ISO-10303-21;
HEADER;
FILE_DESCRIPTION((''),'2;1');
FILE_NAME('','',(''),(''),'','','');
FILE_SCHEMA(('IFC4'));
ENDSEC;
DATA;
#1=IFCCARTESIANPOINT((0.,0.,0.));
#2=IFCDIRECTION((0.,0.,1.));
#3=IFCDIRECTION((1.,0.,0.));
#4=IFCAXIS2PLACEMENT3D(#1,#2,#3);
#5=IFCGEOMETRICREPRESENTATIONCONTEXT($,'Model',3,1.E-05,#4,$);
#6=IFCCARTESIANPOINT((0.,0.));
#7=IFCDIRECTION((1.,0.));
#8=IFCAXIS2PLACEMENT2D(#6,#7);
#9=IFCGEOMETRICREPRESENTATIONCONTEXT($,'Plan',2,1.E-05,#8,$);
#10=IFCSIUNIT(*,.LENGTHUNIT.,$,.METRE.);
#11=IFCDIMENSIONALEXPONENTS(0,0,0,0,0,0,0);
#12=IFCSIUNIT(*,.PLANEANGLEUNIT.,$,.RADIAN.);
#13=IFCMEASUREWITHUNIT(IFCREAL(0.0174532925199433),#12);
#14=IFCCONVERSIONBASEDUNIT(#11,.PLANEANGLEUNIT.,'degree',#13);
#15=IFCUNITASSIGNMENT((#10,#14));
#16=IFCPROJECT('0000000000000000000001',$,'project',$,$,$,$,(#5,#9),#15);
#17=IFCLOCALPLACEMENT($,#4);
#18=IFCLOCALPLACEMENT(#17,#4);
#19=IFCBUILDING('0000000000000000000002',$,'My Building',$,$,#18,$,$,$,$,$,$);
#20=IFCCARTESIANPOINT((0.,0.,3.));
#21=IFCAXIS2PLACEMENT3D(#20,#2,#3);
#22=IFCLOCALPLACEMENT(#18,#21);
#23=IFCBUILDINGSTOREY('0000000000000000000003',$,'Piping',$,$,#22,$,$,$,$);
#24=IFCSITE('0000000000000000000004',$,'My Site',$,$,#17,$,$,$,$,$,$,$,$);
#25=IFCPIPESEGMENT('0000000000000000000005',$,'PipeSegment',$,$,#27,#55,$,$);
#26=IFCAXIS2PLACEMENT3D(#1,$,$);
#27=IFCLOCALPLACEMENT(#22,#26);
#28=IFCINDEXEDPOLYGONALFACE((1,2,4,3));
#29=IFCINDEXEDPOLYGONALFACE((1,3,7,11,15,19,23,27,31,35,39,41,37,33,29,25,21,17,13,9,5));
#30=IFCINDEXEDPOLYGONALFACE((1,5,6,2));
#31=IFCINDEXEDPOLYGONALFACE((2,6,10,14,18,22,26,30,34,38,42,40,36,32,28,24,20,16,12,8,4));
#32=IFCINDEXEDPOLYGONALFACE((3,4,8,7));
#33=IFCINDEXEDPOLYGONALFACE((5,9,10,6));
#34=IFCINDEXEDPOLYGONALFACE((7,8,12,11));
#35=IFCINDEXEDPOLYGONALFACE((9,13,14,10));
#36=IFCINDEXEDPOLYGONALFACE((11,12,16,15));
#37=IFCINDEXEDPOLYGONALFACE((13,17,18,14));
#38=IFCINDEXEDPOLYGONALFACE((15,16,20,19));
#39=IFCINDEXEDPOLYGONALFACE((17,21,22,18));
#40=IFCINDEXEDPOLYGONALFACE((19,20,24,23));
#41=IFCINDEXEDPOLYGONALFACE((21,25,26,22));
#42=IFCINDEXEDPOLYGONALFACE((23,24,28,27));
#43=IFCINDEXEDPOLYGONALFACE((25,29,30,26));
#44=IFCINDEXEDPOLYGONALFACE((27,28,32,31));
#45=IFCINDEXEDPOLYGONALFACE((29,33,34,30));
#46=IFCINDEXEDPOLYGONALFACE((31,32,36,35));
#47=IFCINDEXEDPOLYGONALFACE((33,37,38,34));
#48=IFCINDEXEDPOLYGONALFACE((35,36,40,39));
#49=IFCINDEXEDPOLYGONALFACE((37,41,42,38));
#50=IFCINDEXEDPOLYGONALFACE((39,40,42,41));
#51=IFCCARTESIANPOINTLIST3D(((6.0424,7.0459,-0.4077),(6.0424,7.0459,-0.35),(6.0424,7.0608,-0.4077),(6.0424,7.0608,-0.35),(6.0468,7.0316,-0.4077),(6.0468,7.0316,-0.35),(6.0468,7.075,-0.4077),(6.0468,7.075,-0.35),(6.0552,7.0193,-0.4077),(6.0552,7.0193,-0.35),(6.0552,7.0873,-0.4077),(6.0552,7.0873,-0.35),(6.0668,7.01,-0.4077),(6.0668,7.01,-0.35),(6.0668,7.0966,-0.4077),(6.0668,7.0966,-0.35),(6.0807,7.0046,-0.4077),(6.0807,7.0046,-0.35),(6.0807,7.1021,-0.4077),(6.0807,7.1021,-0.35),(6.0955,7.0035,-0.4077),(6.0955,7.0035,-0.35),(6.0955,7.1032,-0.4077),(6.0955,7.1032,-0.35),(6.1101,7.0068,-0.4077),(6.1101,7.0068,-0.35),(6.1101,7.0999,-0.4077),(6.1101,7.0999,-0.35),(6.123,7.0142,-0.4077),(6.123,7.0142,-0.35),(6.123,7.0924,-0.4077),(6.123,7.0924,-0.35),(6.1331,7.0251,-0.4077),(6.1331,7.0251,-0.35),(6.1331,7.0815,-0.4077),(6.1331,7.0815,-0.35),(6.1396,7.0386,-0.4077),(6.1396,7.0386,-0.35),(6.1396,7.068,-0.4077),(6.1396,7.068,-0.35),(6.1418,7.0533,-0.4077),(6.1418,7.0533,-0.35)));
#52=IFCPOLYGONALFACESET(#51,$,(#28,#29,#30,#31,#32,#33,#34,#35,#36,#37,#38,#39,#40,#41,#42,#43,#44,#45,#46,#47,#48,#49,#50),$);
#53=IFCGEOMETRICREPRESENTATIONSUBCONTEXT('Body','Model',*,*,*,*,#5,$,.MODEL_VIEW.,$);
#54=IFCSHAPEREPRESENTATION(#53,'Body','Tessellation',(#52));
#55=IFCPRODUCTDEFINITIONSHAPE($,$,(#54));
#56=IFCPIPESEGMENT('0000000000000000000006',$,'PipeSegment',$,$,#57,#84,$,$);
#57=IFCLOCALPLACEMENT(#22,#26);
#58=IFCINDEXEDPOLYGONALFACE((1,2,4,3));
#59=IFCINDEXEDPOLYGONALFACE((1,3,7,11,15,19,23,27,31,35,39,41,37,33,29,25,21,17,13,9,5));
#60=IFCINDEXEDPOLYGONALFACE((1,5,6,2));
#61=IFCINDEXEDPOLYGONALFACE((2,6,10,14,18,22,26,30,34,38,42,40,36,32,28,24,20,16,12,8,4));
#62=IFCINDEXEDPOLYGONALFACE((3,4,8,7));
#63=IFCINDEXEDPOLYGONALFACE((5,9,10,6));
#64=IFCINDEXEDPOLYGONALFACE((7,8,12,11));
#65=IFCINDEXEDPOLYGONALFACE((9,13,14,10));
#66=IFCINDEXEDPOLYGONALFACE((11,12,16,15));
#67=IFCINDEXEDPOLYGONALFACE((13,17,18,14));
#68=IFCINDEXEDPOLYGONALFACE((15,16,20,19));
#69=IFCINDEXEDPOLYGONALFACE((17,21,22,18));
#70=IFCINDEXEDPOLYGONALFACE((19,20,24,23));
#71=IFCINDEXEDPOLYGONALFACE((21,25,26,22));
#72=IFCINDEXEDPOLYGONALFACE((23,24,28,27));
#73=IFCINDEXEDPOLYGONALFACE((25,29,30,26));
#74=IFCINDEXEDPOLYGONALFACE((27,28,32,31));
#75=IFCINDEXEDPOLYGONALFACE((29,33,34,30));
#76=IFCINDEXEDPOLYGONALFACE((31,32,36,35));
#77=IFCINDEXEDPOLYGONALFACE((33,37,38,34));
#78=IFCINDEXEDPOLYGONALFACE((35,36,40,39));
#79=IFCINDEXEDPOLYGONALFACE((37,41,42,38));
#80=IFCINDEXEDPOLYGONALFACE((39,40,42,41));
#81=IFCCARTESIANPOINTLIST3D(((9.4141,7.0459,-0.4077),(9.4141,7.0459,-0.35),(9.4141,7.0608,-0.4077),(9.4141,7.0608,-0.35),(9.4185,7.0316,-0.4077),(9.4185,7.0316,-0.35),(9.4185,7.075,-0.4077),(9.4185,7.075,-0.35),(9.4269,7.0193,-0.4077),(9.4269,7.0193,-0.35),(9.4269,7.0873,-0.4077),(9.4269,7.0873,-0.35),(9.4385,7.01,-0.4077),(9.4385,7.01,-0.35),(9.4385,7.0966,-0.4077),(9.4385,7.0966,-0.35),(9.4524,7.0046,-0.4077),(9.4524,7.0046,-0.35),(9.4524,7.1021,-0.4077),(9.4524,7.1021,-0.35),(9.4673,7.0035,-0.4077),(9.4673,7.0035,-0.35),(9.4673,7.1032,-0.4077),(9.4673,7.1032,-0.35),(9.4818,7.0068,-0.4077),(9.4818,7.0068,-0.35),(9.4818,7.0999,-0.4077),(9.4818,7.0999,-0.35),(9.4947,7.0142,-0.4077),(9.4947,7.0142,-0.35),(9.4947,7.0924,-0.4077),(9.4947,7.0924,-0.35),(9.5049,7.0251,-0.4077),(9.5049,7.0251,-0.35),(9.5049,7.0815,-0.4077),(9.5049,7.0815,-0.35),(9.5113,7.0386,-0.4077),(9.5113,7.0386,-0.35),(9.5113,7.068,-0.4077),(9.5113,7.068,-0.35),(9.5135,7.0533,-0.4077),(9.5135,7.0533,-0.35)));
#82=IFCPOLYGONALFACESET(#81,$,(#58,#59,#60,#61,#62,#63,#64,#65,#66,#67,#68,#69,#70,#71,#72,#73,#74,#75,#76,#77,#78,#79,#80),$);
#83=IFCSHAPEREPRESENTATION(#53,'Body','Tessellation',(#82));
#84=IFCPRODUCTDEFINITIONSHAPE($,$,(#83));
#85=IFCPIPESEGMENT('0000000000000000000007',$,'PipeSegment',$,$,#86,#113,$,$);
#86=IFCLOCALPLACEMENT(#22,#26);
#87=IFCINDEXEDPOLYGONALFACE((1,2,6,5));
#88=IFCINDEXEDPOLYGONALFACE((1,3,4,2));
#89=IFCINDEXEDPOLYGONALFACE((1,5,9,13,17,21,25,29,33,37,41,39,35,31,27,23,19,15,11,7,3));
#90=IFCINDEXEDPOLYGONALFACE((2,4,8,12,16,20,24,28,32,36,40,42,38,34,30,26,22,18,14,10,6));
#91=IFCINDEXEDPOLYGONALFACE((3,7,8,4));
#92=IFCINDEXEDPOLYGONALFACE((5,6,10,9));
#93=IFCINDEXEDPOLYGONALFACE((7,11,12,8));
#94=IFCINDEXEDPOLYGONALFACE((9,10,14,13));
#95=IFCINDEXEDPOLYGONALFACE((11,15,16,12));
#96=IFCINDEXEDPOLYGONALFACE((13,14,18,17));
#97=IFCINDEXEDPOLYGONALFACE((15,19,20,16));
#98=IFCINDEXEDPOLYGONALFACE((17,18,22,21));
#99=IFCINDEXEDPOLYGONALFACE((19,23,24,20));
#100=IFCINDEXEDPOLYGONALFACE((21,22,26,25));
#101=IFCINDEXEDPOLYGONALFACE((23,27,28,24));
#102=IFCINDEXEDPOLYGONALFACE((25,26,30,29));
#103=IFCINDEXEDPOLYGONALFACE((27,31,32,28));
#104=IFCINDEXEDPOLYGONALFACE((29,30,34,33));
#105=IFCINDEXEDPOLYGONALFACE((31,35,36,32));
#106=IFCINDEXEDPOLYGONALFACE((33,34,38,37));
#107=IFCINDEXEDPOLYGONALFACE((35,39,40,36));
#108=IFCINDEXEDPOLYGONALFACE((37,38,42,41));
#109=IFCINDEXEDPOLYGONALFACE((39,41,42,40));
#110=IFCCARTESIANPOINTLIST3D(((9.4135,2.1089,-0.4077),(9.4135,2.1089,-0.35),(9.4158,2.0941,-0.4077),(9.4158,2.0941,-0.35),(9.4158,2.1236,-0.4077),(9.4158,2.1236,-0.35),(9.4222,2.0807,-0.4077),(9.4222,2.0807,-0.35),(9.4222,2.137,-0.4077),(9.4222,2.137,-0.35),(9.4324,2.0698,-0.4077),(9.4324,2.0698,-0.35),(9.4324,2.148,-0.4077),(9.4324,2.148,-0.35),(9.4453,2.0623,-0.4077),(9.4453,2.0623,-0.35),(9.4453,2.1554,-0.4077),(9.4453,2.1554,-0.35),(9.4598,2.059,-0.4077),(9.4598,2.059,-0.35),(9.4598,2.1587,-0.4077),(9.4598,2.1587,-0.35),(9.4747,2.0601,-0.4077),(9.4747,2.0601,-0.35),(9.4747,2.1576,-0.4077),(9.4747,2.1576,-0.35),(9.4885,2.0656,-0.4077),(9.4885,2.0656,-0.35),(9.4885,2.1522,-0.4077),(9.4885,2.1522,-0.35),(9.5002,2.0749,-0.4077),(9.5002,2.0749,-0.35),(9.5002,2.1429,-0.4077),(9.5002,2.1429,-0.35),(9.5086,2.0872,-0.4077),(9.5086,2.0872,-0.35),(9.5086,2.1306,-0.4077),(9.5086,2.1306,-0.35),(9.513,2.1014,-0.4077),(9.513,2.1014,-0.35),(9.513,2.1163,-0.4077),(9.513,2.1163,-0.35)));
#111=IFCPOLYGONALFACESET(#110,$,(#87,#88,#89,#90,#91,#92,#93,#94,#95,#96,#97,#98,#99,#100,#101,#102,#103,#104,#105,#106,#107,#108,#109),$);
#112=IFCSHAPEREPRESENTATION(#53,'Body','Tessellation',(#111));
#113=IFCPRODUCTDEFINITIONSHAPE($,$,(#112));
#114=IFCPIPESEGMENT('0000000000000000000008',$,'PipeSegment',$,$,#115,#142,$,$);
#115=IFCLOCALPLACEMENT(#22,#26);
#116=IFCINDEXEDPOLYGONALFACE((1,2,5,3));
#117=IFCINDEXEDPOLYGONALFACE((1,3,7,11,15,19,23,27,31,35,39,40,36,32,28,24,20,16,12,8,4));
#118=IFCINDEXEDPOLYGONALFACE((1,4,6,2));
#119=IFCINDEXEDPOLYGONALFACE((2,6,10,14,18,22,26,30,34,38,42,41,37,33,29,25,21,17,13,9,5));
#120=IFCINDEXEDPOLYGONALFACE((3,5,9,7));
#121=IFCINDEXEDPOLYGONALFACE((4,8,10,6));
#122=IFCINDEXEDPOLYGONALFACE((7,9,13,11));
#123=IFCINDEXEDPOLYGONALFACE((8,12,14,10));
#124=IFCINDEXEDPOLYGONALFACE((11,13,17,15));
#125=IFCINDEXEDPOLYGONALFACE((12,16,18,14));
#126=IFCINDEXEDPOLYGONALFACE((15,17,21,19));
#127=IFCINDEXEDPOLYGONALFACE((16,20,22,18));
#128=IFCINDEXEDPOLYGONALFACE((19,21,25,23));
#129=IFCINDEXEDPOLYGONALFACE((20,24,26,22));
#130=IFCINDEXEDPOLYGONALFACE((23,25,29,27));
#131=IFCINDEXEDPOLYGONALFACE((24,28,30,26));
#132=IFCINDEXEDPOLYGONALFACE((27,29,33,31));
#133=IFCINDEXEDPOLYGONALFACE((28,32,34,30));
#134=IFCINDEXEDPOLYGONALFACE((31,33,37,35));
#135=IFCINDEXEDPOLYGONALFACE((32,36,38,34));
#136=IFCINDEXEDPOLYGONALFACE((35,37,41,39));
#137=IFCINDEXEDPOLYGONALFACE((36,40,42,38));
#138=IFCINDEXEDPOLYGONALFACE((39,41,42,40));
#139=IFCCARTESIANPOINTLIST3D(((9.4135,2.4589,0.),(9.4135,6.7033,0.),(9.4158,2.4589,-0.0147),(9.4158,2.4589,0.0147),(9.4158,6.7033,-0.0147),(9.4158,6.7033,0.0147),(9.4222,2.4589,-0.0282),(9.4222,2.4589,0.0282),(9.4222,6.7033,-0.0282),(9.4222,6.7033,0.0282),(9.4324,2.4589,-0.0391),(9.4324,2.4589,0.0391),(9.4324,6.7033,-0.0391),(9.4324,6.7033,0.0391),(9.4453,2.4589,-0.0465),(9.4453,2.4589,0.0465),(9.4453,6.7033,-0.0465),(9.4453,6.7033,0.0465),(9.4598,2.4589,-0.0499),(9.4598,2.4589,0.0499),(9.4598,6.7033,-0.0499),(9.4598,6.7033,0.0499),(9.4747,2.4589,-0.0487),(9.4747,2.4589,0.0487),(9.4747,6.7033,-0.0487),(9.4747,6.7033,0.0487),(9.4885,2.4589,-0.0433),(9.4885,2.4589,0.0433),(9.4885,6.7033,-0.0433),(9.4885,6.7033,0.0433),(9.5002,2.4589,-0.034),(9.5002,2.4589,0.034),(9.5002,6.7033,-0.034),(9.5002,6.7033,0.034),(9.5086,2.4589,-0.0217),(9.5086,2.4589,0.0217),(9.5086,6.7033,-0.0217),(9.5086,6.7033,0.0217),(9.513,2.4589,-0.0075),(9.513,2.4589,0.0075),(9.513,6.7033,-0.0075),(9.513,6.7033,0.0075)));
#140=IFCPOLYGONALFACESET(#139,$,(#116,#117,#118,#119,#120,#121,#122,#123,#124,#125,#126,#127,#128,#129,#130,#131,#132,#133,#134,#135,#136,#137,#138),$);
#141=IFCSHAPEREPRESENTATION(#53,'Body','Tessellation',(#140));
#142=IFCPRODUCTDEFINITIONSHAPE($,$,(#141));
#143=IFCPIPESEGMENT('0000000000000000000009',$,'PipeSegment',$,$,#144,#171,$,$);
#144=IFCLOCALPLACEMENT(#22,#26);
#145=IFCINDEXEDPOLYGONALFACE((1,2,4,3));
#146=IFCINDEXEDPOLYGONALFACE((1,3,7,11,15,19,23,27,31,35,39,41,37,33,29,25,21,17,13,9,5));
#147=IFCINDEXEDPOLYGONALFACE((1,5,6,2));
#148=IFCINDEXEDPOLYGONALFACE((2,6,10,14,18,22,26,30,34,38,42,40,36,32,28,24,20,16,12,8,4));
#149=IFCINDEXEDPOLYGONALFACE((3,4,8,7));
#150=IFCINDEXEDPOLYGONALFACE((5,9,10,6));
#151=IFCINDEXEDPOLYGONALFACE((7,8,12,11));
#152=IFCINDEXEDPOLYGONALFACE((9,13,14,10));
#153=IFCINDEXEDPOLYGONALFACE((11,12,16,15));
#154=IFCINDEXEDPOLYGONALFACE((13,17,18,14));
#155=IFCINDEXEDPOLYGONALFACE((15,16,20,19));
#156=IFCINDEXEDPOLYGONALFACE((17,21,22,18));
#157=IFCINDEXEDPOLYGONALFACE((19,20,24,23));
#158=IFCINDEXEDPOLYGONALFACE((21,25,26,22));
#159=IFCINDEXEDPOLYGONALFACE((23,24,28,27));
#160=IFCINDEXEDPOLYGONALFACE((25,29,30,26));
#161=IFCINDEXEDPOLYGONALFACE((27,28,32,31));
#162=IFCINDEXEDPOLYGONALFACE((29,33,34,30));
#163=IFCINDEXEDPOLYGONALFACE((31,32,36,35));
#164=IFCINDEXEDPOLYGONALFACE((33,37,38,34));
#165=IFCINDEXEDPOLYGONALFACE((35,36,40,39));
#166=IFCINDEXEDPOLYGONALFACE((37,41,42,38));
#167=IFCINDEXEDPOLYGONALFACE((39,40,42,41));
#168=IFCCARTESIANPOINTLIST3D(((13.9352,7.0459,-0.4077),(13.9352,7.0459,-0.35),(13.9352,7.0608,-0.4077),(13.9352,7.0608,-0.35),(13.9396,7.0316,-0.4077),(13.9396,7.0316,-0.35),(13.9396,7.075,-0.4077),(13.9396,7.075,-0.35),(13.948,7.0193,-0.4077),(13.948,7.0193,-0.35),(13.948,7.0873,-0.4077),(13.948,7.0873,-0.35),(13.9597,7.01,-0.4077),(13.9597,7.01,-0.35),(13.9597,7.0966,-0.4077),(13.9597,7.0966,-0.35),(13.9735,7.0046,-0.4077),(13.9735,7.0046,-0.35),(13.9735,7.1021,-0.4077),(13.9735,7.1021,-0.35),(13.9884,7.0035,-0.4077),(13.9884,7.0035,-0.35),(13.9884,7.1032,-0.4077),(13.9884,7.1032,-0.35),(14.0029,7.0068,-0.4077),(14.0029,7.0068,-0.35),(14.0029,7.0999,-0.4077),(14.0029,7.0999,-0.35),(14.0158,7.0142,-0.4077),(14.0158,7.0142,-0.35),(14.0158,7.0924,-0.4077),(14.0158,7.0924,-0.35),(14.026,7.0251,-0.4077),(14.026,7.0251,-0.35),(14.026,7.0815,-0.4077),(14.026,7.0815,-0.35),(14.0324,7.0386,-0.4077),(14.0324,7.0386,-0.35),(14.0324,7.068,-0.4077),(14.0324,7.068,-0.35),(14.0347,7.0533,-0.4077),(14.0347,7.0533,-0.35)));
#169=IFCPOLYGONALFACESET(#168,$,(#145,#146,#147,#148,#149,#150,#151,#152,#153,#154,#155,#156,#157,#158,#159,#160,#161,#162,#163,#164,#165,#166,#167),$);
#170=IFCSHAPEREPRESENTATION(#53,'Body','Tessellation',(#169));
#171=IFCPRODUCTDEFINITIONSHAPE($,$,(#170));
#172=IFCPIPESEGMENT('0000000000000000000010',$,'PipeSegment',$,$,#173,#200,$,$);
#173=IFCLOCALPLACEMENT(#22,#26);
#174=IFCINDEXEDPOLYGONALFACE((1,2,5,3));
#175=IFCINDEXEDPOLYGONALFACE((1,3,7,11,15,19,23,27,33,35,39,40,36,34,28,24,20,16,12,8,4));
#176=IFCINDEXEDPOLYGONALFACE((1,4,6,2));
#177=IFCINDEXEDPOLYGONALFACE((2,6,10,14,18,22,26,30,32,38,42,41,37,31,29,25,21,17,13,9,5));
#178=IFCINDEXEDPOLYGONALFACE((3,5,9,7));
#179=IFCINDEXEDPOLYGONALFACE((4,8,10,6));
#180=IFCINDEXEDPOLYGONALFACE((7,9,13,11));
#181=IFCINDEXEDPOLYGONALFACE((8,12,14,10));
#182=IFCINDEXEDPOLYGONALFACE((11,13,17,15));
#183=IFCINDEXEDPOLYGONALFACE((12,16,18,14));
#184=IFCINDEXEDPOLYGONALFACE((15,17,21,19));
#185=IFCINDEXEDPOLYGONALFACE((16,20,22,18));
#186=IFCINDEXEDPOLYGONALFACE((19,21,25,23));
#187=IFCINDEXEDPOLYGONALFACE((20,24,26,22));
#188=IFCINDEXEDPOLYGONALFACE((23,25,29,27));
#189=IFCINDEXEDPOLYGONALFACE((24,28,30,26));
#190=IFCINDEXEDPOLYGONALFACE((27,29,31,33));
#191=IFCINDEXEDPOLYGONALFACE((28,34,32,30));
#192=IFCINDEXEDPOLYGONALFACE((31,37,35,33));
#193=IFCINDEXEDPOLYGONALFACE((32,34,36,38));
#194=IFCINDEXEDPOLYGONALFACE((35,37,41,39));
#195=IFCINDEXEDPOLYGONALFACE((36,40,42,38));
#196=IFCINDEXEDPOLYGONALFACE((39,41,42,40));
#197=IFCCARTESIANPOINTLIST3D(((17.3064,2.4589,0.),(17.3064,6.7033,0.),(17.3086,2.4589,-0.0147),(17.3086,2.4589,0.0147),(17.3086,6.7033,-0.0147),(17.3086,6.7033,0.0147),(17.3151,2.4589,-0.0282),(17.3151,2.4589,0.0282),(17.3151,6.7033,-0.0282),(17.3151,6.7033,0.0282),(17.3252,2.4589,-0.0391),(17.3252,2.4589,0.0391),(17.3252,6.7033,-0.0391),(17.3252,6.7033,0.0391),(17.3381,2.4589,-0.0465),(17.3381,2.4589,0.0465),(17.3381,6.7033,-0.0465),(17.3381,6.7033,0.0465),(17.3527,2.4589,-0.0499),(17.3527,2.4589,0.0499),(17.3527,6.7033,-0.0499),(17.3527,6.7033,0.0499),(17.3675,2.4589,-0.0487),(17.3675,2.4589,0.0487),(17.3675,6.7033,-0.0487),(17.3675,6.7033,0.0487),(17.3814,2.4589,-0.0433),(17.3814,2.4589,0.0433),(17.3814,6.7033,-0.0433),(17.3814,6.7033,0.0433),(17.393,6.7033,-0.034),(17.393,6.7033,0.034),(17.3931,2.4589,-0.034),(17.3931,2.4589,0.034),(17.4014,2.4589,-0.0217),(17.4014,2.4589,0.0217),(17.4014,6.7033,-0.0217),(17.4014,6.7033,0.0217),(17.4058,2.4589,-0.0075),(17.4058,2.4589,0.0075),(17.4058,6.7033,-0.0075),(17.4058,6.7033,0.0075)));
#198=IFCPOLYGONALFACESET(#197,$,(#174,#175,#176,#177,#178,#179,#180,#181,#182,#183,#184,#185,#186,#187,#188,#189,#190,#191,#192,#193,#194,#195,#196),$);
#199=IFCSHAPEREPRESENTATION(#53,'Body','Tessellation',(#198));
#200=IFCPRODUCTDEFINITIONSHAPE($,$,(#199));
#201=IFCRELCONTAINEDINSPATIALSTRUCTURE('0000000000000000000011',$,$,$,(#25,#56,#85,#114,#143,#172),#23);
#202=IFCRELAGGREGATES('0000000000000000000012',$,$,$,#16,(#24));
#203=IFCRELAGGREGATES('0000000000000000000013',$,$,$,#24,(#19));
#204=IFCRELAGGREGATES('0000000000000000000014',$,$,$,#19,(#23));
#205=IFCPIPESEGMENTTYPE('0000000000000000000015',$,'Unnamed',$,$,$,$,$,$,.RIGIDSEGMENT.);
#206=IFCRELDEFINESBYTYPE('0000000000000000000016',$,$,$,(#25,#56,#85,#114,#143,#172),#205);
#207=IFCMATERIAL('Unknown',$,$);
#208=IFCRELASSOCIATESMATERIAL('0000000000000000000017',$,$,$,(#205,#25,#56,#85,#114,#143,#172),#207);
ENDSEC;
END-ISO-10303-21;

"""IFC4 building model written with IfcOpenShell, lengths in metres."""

from ifc_helpers import new_model, entity, si_unit, converted_unit, frame, origin_with_axes, origin_2d_with_axis, place, context, subcontext, project, spatial, circle, extrude, material, material_profile, profile_set, profile_usage, type_object, element, save


model = new_model("IFC4")

# Units and contexts
model_context = context("Model", 3, precision=1e-05, world=origin_with_axes())
plan_context = context("Plan", 2, precision=1e-05, world=origin_2d_with_axis())
body_context = subcontext(model_context, "Body", "Model", "MODEL_VIEW")
ifc_project = project(units=[si_unit("LENGTHUNIT", "METRE"), converted_unit("PLANEANGLEUNIT", "degree", entity("IfcReal", 0.0174532925199433), si_unit("PLANEANGLEUNIT", "RADIAN"), dimensions=[0, 0, 0, 0, 0, 0, 0])], contexts=[model_context, plan_context])

# Site, building, storey
site_placement = place(None, origin_with_axes())
site = spatial("IfcSite", under=ifc_project, at=site_placement, Name="My Site")
building_placement = place(site_placement, origin_with_axes())
building = spatial("IfcBuilding", under=site, at=building_placement, Name="My Building")
storey_placement = place(building_placement, frame((0.0, 0.0, 3.0), z_axis=(0.0, 0.0, 1.0), x_axis=(1.0, 0.0, 0.0)))
storey = spatial("IfcBuildingStorey", under=building, at=storey_placement, Name="Piping")

# Pipe segments
ifc_material = material(Name="Unknown")
ifc_material_profile = material_profile(ifc_material, circle(Radius=0.05))
ifc_profile_set = profile_set([ifc_material_profile])
pipe_segment_type = type_object("IfcPipeSegmentType", Name="Unnamed", PredefinedType="RIGIDSEGMENT", material=ifc_profile_set)
ifc_profile_usage_1 = profile_usage(ifc_profile_set, cardinal=5)
pipe_segment_1_placement = place(storey_placement, frame((6.0918, 7.0533, -0.35), z_axis=(0.0, 0.0, -1.0), x_axis=(1.0, 0.0, 0.0)))
element("IfcPipeSegment", 1, at=pipe_segment_1_placement, inside=storey, type_object=pipe_segment_type, material=ifc_profile_usage_1, Name="PipeSegment", context=body_context, shape_type="SweptSolid", body=[
    extrude(circle(Radius=0.05), origin_with_axes(), (0.0, 0.0, 1.0), 0.0577),
])
ifc_profile_usage_2 = profile_usage(ifc_profile_set, cardinal=5)
pipe_segment_2_placement = place(storey_placement, frame((9.4635, 7.0533, -0.35), z_axis=(0.0, 0.0, -1.0), x_axis=(1.0, 0.0, 0.0)))
element("IfcPipeSegment", 2, at=pipe_segment_2_placement, inside=storey, type_object=pipe_segment_type, material=ifc_profile_usage_2, Name="PipeSegment", context=body_context, shape_type="SweptSolid", body=[
    extrude(circle(Radius=0.05), origin_with_axes(), (0.0, 0.0, 1.0), 0.0577),
])
ifc_profile_usage_3 = profile_usage(ifc_profile_set, cardinal=5)
pipe_segment_3_placement = place(storey_placement, frame((9.4635, 2.1089, -0.35), z_axis=(0.0, 0.0, -1.0), x_axis=(-1.0, 0.0, 0.0)))
element("IfcPipeSegment", 3, at=pipe_segment_3_placement, inside=storey, type_object=pipe_segment_type, material=ifc_profile_usage_3, Name="PipeSegment", context=body_context, shape_type="SweptSolid", body=[
    extrude(circle(Radius=0.05), origin_with_axes(), (0.0, 0.0, 1.0), 0.0577),
])
ifc_profile_usage_4 = profile_usage(ifc_profile_set, cardinal=5)
pipe_segment_4_placement = place(storey_placement, frame((9.4635, 2.4589, 0.0), z_axis=(0.0, 1.0, 0.0), x_axis=(-1.0, 0.0, 0.0)))
element("IfcPipeSegment", 4, at=pipe_segment_4_placement, inside=storey, type_object=pipe_segment_type, material=ifc_profile_usage_4, Name="PipeSegment", context=body_context, shape_type="SweptSolid", body=[
    extrude(circle(Radius=0.05), origin_with_axes(), (0.0, 0.0, 1.0), 4.2444),
])
ifc_profile_usage_5 = profile_usage(ifc_profile_set, cardinal=5)
pipe_segment_5_placement = place(storey_placement, frame((13.9847, 7.0533, -0.35), z_axis=(0.0, 0.0, -1.0), x_axis=(1.0, 0.0, 0.0)))
element("IfcPipeSegment", 5, at=pipe_segment_5_placement, inside=storey, type_object=pipe_segment_type, material=ifc_profile_usage_5, Name="PipeSegment", context=body_context, shape_type="SweptSolid", body=[
    extrude(circle(Radius=0.05), origin_with_axes(), (0.0, 0.0, 1.0), 0.0577),
])
ifc_profile_usage_6 = profile_usage(ifc_profile_set, cardinal=5)
pipe_segment_6_placement = place(storey_placement, frame((17.3564, 2.4589, 0.0), z_axis=(0.0, 1.0, 0.0), x_axis=(-1.0, 0.0, 0.0)))
element("IfcPipeSegment", 6, at=pipe_segment_6_placement, inside=storey, type_object=pipe_segment_type, material=ifc_profile_usage_6, Name="PipeSegment", context=body_context, shape_type="SweptSolid", body=[
    extrude(circle(Radius=0.05), origin_with_axes(), (0.0, 0.0, 1.0), 4.2444),
])

save(model, "model.ifc")
